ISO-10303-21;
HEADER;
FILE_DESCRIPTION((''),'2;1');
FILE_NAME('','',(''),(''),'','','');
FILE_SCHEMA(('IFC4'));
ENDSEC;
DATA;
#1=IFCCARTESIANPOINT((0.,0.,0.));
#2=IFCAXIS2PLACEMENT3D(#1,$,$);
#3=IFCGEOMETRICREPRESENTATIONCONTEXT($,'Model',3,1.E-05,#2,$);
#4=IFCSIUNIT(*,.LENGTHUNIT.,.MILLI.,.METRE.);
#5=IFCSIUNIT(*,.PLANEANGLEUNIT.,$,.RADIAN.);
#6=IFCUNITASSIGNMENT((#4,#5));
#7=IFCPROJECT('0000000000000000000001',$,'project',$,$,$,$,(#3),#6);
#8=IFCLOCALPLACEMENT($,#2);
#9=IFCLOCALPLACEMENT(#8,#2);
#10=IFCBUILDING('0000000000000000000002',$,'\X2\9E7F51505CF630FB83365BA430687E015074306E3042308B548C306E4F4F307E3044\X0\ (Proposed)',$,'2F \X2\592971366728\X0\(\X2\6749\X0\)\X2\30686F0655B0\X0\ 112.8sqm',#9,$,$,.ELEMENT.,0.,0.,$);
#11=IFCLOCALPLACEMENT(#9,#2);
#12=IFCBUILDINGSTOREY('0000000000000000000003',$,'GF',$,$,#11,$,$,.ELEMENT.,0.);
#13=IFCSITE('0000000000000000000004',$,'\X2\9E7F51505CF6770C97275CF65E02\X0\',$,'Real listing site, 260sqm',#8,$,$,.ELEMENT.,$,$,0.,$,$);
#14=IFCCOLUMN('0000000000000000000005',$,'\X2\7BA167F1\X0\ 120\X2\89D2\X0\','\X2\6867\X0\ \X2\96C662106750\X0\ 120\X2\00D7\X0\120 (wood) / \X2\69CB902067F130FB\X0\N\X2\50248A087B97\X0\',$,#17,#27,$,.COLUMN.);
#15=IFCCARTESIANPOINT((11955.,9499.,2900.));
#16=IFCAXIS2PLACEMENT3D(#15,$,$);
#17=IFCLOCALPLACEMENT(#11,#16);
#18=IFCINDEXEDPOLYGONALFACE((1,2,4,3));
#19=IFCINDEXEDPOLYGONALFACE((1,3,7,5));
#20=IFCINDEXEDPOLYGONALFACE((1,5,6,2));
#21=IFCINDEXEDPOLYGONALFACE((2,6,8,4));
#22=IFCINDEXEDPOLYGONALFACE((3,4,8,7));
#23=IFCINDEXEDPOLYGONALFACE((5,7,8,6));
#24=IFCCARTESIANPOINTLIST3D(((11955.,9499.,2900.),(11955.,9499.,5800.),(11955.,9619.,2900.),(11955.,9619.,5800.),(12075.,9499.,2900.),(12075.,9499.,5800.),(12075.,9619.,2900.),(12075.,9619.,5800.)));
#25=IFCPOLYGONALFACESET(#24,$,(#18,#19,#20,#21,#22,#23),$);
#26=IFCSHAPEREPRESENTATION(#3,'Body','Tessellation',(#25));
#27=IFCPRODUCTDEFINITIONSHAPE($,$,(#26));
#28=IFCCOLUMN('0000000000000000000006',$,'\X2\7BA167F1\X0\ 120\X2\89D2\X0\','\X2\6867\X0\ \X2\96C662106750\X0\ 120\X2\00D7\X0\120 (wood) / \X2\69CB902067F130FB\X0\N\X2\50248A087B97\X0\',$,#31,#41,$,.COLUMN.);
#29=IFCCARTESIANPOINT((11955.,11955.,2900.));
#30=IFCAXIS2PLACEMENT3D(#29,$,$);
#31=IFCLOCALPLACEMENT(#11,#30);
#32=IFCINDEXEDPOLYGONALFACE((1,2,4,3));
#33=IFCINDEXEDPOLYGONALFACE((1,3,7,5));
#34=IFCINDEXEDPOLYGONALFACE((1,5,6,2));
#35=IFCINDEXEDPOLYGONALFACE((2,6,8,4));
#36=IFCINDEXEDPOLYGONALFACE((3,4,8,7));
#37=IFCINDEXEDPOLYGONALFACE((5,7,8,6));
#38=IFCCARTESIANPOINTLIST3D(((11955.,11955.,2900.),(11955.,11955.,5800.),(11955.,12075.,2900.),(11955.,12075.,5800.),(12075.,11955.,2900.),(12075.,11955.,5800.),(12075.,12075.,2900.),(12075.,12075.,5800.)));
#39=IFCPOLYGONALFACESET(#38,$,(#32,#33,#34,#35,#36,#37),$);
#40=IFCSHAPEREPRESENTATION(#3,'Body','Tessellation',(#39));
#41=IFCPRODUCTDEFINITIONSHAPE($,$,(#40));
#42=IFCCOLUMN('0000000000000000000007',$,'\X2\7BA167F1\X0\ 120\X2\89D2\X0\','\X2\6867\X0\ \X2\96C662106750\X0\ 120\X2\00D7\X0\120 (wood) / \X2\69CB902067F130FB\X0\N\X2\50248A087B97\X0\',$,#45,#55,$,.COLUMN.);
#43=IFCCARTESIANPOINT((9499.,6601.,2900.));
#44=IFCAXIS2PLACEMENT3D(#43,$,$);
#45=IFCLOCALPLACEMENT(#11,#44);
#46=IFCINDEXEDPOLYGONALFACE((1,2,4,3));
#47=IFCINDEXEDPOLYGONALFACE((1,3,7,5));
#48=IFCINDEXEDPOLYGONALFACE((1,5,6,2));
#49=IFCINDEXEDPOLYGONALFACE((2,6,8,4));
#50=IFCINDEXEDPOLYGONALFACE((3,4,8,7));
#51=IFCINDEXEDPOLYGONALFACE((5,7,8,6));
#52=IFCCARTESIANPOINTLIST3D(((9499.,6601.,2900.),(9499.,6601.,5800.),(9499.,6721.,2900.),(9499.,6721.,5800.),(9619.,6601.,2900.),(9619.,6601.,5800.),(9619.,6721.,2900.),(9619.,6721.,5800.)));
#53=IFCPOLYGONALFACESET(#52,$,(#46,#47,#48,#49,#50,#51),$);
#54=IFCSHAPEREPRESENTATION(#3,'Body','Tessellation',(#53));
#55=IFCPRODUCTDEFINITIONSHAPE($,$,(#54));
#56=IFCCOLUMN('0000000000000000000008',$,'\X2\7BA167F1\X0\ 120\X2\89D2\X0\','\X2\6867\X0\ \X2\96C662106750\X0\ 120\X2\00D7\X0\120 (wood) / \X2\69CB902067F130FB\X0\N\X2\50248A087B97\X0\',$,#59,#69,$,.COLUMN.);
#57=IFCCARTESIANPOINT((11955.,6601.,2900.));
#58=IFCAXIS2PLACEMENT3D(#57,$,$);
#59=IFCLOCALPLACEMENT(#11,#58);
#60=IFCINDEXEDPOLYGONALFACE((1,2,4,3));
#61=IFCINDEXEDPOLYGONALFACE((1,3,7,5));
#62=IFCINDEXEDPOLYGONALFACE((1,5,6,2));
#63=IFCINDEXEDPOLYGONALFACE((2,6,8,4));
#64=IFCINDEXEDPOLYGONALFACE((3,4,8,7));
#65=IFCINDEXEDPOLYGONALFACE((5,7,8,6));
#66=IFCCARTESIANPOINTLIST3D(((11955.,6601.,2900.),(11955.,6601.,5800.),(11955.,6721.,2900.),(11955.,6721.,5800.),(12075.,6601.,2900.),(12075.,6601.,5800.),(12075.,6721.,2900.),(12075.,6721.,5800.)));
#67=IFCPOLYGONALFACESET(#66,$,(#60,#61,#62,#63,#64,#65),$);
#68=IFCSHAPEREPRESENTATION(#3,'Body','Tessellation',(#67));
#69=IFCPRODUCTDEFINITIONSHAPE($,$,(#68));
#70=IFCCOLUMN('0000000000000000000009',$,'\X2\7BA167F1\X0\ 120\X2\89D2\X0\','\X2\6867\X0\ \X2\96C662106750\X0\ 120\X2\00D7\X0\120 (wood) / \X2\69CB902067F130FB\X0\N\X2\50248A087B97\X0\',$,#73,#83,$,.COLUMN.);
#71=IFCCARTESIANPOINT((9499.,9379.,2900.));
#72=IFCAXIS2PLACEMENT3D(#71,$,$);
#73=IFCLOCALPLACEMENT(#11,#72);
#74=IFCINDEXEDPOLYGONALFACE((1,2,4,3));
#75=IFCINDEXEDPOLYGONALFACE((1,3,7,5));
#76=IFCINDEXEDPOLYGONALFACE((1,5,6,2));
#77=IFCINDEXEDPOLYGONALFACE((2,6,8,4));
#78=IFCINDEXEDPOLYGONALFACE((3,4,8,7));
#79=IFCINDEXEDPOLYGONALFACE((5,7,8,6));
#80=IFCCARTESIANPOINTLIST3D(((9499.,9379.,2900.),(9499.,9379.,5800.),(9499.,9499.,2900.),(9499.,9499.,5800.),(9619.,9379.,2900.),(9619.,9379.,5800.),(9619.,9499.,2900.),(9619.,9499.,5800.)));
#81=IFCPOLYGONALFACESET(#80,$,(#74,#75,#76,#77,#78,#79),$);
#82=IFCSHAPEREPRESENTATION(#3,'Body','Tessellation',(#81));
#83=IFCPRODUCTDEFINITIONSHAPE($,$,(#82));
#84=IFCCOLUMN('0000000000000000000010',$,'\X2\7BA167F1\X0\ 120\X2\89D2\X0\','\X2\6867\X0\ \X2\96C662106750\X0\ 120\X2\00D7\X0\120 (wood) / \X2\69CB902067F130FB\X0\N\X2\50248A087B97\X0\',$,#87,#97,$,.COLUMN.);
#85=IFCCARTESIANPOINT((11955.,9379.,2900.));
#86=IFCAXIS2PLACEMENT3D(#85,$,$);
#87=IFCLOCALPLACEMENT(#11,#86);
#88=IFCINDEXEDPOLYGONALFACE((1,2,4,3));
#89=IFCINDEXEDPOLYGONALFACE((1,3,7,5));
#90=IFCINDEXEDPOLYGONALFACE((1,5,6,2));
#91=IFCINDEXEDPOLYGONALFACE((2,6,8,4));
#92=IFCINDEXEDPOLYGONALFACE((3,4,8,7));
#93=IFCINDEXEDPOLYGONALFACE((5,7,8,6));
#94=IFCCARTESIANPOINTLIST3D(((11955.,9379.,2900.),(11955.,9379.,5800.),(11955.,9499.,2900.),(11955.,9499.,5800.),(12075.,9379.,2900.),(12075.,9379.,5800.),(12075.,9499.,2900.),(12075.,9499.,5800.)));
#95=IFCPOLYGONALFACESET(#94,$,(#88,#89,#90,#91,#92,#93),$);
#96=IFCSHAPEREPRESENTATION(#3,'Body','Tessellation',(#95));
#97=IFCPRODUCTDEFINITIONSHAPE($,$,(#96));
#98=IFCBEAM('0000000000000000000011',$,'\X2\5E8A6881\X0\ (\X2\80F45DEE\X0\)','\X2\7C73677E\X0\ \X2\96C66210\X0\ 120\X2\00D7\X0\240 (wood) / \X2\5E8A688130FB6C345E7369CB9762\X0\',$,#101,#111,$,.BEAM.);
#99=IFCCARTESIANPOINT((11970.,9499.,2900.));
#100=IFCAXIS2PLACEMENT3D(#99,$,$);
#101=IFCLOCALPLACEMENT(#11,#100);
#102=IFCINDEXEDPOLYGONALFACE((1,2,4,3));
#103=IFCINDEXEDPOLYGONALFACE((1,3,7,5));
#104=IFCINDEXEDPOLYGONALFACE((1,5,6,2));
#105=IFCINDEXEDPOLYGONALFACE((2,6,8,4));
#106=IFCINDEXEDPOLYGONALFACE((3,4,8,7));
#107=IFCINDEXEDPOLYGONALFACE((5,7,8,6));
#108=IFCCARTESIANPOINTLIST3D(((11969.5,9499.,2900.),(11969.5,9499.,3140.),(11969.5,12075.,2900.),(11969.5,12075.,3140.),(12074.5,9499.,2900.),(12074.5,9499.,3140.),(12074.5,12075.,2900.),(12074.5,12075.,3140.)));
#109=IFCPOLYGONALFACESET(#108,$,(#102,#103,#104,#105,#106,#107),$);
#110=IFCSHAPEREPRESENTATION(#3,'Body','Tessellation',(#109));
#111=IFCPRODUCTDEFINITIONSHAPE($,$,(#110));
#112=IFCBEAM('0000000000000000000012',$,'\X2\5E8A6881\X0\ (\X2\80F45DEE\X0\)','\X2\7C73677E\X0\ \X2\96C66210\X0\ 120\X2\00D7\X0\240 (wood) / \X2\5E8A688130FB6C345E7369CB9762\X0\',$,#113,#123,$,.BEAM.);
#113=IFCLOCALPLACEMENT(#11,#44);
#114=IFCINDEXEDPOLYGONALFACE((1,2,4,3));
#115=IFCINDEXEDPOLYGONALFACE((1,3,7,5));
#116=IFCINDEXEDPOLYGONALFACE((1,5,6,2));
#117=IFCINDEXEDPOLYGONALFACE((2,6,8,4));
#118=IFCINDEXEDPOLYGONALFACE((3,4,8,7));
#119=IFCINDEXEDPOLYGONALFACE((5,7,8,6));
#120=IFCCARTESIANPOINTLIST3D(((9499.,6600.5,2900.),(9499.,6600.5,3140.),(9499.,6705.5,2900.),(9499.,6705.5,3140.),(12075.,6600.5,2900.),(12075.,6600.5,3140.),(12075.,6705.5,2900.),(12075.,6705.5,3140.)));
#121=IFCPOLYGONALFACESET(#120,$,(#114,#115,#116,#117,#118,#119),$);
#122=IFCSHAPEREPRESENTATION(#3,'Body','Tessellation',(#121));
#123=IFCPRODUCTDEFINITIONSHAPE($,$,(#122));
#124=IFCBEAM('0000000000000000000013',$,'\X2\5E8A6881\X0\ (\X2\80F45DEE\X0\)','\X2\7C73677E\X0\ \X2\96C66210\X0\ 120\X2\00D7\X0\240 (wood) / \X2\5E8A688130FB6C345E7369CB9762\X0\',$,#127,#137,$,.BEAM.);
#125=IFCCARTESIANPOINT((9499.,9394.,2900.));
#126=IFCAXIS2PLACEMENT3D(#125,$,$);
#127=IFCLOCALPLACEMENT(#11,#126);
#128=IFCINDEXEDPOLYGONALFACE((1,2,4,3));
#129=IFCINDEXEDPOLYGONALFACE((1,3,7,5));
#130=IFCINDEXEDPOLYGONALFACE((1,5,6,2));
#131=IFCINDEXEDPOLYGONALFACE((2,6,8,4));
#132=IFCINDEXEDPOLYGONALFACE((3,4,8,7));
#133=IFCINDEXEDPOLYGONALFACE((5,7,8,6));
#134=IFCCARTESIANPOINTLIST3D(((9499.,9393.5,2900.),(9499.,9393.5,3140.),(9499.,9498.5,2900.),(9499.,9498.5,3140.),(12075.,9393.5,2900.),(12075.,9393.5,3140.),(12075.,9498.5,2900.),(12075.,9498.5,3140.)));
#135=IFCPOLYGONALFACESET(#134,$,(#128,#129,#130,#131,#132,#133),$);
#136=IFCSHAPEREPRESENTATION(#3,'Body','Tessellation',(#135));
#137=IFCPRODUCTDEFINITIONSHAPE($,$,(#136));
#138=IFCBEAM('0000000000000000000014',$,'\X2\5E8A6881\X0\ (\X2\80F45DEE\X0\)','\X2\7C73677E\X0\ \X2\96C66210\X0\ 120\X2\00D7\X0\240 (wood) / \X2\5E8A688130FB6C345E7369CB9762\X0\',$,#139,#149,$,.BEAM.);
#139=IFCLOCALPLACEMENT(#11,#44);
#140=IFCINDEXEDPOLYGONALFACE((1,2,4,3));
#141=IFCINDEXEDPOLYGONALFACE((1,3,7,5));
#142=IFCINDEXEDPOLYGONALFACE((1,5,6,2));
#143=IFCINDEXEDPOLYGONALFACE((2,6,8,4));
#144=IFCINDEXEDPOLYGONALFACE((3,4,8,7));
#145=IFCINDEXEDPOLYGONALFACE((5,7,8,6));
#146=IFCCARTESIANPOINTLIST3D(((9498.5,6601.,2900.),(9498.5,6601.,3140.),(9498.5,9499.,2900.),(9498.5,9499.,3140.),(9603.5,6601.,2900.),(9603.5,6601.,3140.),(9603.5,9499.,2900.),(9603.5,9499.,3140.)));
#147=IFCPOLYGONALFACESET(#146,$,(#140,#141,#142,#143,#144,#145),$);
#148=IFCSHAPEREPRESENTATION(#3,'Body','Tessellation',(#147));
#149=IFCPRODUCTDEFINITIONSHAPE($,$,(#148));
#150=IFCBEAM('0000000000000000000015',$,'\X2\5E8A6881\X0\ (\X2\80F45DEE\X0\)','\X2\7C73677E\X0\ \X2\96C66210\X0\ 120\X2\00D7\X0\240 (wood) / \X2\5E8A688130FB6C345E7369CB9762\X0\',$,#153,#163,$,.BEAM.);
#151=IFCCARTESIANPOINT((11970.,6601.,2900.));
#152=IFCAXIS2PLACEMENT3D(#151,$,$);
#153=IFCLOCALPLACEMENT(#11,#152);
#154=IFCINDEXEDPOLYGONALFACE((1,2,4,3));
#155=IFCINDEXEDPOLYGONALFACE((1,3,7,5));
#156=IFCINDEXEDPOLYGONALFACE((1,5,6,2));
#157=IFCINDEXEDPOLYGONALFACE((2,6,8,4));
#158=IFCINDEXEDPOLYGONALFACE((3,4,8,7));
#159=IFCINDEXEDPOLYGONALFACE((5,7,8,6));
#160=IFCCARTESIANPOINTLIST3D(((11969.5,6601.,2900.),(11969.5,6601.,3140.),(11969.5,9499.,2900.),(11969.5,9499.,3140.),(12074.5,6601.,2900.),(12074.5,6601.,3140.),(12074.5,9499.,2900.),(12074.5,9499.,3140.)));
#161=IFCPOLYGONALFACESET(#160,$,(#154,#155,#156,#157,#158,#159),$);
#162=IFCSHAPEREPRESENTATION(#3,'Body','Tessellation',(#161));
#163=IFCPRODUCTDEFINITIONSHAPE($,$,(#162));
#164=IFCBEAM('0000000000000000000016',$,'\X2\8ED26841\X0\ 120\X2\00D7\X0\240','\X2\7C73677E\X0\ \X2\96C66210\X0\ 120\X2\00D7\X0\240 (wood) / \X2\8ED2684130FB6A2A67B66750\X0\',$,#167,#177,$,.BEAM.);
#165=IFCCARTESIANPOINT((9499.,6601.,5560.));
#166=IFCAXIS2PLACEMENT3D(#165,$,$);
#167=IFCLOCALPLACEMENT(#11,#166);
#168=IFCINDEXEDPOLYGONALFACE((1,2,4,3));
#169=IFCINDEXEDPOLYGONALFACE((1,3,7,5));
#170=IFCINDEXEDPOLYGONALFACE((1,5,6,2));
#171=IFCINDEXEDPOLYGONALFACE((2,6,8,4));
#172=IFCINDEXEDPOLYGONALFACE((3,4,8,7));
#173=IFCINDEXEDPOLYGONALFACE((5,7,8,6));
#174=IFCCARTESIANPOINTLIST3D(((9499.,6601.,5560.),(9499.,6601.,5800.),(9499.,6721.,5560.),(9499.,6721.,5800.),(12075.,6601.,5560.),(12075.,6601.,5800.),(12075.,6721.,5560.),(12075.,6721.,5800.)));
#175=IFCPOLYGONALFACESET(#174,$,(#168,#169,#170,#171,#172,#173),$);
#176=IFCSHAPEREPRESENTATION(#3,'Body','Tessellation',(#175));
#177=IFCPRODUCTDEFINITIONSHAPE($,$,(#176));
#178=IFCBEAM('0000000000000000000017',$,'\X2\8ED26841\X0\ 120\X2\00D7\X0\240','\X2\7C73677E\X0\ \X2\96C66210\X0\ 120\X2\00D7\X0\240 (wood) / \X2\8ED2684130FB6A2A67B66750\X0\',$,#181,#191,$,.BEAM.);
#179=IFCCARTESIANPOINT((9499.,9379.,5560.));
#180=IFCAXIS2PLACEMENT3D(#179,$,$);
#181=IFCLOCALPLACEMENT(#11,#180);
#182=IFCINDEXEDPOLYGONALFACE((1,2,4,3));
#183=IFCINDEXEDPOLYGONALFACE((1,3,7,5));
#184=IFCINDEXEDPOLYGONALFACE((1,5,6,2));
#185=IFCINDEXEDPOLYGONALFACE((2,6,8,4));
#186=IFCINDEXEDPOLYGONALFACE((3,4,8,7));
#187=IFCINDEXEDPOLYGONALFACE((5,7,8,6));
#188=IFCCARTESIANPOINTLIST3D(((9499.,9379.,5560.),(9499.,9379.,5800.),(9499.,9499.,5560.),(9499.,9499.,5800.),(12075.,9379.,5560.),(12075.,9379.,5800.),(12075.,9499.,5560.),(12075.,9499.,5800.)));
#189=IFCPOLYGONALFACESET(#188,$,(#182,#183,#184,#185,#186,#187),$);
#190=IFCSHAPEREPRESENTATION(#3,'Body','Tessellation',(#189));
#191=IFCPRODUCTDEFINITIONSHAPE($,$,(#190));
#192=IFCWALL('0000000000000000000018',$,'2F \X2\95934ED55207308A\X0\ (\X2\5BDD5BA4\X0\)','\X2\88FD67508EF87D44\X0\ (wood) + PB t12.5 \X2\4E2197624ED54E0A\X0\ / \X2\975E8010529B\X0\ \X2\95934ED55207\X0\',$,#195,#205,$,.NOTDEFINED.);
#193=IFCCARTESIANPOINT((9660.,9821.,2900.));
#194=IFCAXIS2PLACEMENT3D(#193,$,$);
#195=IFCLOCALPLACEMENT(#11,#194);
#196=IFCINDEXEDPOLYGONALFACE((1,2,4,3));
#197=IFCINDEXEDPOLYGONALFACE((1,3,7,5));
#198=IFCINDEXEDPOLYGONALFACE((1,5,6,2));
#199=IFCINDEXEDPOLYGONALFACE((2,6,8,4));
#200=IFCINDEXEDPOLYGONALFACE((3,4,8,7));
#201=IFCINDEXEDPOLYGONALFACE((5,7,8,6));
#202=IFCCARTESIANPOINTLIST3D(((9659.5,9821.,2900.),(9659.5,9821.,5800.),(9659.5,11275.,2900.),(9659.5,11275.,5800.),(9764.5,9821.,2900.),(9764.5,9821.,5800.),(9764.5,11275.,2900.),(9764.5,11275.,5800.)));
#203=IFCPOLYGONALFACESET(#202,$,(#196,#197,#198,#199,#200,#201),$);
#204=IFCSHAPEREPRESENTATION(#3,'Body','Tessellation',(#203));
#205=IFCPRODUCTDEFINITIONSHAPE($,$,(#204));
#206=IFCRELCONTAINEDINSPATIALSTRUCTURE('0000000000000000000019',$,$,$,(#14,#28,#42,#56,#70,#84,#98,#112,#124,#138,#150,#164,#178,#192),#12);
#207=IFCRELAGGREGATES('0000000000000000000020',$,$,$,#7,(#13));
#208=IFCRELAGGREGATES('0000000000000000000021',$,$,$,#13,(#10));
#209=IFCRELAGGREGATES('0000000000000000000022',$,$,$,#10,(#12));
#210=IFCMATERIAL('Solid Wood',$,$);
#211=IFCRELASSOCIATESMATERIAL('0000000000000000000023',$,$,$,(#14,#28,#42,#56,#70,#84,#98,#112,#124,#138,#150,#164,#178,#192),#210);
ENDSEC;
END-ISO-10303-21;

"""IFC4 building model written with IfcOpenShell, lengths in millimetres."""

from ifc_helpers import new_model, si_unit, frame, frame_2d, origin, place, context, project, spatial, rectangle, extrude, material, element, save


model = new_model("IFC4")

# Units and contexts
model_context = context("Model", 3, precision=1e-05, world=origin())
ifc_project = project(units=[si_unit("LENGTHUNIT", "METRE", prefix="MILLI"), si_unit("PLANEANGLEUNIT", "RADIAN")], contexts=[model_context])

# Site, building, storey
site_placement = place(None, origin())
site = spatial("IfcSite", under=ifc_project, at=site_placement, Name="鹿児島県霧島市", ObjectType="Real listing site, 260sqm", CompositionType="ELEMENT", RefElevation=0.0)
building_placement = place(site_placement, origin())
building = spatial("IfcBuilding", under=site, at=building_placement, Name="鹿児島・茶室と縁側のある和の住まい (Proposed)", ObjectType="2F 天然木(杉)と漆喰 112.8sqm", CompositionType="ELEMENT", ElevationOfRefHeight=0.0, ElevationOfTerrain=0.0)
storey_placement = place(building_placement, origin())
storey = spatial("IfcBuildingStorey", under=building, at=storey_placement, Name="GF", CompositionType="ELEMENT", Elevation=0.0)

# Columns
ifc_material_1 = material(Name="Solid Wood")
column_1_placement = place(storey_placement, frame((11955.0, 9499.0, 2900.0)))
element("IfcColumn", 1, at=column_1_placement, inside=storey, material=ifc_material_1, Name="管柱 120角", Description="桧 集成材 120×120 (wood) / 構造柱・N値計算", PredefinedType="COLUMN", context=model_context, shape_type="SweptSolid", body=[
    extrude(rectangle(XDim=120.0, YDim=120.0, at=frame_2d((60.0, 60.0))), frame((11955.0, 9499.0, 2900.0)), (0.0, 0.0, 1.0), 2900.0),
])
column_2_placement = place(storey_placement, frame((11955.0, 11955.0, 2900.0)))
element("IfcColumn", 2, at=column_2_placement, inside=storey, material=ifc_material_1, Name="管柱 120角", Description="桧 集成材 120×120 (wood) / 構造柱・N値計算", PredefinedType="COLUMN", context=model_context, shape_type="SweptSolid", body=[
    extrude(rectangle(XDim=120.0, YDim=120.0, at=frame_2d((60.0, 60.0))), frame((11955.0, 11955.0, 2900.0)), (0.0, 0.0, 1.0), 2900.0),
])
column_3_placement = place(storey_placement, frame((9499.0, 6601.0, 2900.0)))
element("IfcColumn", 3, at=column_3_placement, inside=storey, material=ifc_material_1, Name="管柱 120角", Description="桧 集成材 120×120 (wood) / 構造柱・N値計算", PredefinedType="COLUMN", context=model_context, shape_type="SweptSolid", body=[
    extrude(rectangle(XDim=120.0, YDim=120.0, at=frame_2d((60.0, 60.0))), frame((9499.0, 6601.0, 2900.0)), (0.0, 0.0, 1.0), 2900.0),
])
column_4_placement = place(storey_placement, frame((11955.0, 6601.0, 2900.0)))
element("IfcColumn", 4, at=column_4_placement, inside=storey, material=ifc_material_1, Name="管柱 120角", Description="桧 集成材 120×120 (wood) / 構造柱・N値計算", PredefinedType="COLUMN", context=model_context, shape_type="SweptSolid", body=[
    extrude(rectangle(XDim=120.0, YDim=120.0, at=frame_2d((60.0, 60.0))), frame((11955.0, 6601.0, 2900.0)), (0.0, 0.0, 1.0), 2900.0),
])
column_5_placement = place(storey_placement, frame((9499.0, 9379.0, 2900.0)))
element("IfcColumn", 5, at=column_5_placement, inside=storey, material=ifc_material_1, Name="管柱 120角", Description="桧 集成材 120×120 (wood) / 構造柱・N値計算", PredefinedType="COLUMN", context=model_context, shape_type="SweptSolid", body=[
    extrude(rectangle(XDim=120.0, YDim=120.0, at=frame_2d((60.0, 60.0))), frame((9499.0, 9379.0, 2900.0)), (0.0, 0.0, 1.0), 2900.0),
])
column_6_placement = place(storey_placement, frame((11955.0, 9379.0, 2900.0)))
element("IfcColumn", 6, at=column_6_placement, inside=storey, material=ifc_material_1, Name="管柱 120角", Description="桧 集成材 120×120 (wood) / 構造柱・N値計算", PredefinedType="COLUMN", context=model_context, shape_type="SweptSolid", body=[
    extrude(rectangle(XDim=120.0, YDim=120.0, at=frame_2d((60.0, 60.0))), frame((11955.0, 9379.0, 2900.0)), (0.0, 0.0, 1.0), 2900.0),
])

# Beams
beam_1_placement = place(storey_placement, frame((11970.0, 9499.0, 2900.0)))
element("IfcBeam", 7, at=beam_1_placement, inside=storey, material=ifc_material_1, Name="床梁 (胴差)", Description="米松 集成 120×240 (wood) / 床梁・水平構面", PredefinedType="BEAM", context=model_context, shape_type="SweptSolid", body=[
    extrude(rectangle(XDim=105.0, YDim=2576.0, at=frame_2d((52.0, 1288.0))), frame((11970.0, 9499.0, 2900.0)), (0.0, 0.0, 1.0), 240.0),
])
beam_2_placement = place(storey_placement, frame((9499.0, 6601.0, 2900.0)))
element("IfcBeam", 8, at=beam_2_placement, inside=storey, material=ifc_material_1, Name="床梁 (胴差)", Description="米松 集成 120×240 (wood) / 床梁・水平構面", PredefinedType="BEAM", context=model_context, shape_type="SweptSolid", body=[
    extrude(rectangle(XDim=2576.0, YDim=105.0, at=frame_2d((1288.0, 52.0))), frame((9499.0, 6601.0, 2900.0)), (0.0, 0.0, 1.0), 240.0),
])
beam_3_placement = place(storey_placement, frame((9499.0, 9394.0, 2900.0)))
element("IfcBeam", 9, at=beam_3_placement, inside=storey, material=ifc_material_1, Name="床梁 (胴差)", Description="米松 集成 120×240 (wood) / 床梁・水平構面", PredefinedType="BEAM", context=model_context, shape_type="SweptSolid", body=[
    extrude(rectangle(XDim=2576.0, YDim=105.0, at=frame_2d((1288.0, 52.0))), frame((9499.0, 9394.0, 2900.0)), (0.0, 0.0, 1.0), 240.0),
])
beam_4_placement = place(storey_placement, frame((9499.0, 6601.0, 2900.0)))
element("IfcBeam", 10, at=beam_4_placement, inside=storey, material=ifc_material_1, Name="床梁 (胴差)", Description="米松 集成 120×240 (wood) / 床梁・水平構面", PredefinedType="BEAM", context=model_context, shape_type="SweptSolid", body=[
    extrude(rectangle(XDim=105.0, YDim=2898.0, at=frame_2d((52.0, 1449.0))), frame((9499.0, 6601.0, 2900.0)), (0.0, 0.0, 1.0), 240.0),
])
beam_5_placement = place(storey_placement, frame((11970.0, 6601.0, 2900.0)))
element("IfcBeam", 11, at=beam_5_placement, inside=storey, material=ifc_material_1, Name="床梁 (胴差)", Description="米松 集成 120×240 (wood) / 床梁・水平構面", PredefinedType="BEAM", context=model_context, shape_type="SweptSolid", body=[
    extrude(rectangle(XDim=105.0, YDim=2898.0, at=frame_2d((52.0, 1449.0))), frame((11970.0, 6601.0, 2900.0)), (0.0, 0.0, 1.0), 240.0),
])
beam_6_placement = place(storey_placement, frame((9499.0, 6601.0, 5560.0)))
element("IfcBeam", 12, at=beam_6_placement, inside=storey, material=ifc_material_1, Name="軒桁 120×240", Description="米松 集成 120×240 (wood) / 軒桁・横架材", PredefinedType="BEAM", context=model_context, shape_type="SweptSolid", body=[
    extrude(rectangle(XDim=2576.0, YDim=120.0, at=frame_2d((1288.0, 60.0))), frame((9499.0, 6601.0, 5560.0)), (0.0, 0.0, 1.0), 240.0),
])
beam_7_placement = place(storey_placement, frame((9499.0, 9379.0, 5560.0)))
element("IfcBeam", 13, at=beam_7_placement, inside=storey, material=ifc_material_1, Name="軒桁 120×240", Description="米松 集成 120×240 (wood) / 軒桁・横架材", PredefinedType="BEAM", context=model_context, shape_type="SweptSolid", body=[
    extrude(rectangle(XDim=2576.0, YDim=120.0, at=frame_2d((1288.0, 60.0))), frame((9499.0, 9379.0, 5560.0)), (0.0, 0.0, 1.0), 240.0),
])

# Wall
wall_placement = place(storey_placement, frame((9660.0, 9821.0, 2900.0)))
element("IfcWall", 14, at=wall_placement, inside=storey, material=ifc_material_1, Name="2F 間仕切り (寝室)", Description="製材軸組 (wood) + PB t12.5 両面仕上 / 非耐力 間仕切", PredefinedType="NOTDEFINED", context=model_context, shape_type="SweptSolid", body=[
    extrude(rectangle(XDim=105.0, YDim=1454.0, at=frame_2d((52.0, 727.0))), frame((9660.0, 9821.0, 2900.0)), (0.0, 0.0, 1.0), 2900.0),
])

save(model, "model.ifc")
